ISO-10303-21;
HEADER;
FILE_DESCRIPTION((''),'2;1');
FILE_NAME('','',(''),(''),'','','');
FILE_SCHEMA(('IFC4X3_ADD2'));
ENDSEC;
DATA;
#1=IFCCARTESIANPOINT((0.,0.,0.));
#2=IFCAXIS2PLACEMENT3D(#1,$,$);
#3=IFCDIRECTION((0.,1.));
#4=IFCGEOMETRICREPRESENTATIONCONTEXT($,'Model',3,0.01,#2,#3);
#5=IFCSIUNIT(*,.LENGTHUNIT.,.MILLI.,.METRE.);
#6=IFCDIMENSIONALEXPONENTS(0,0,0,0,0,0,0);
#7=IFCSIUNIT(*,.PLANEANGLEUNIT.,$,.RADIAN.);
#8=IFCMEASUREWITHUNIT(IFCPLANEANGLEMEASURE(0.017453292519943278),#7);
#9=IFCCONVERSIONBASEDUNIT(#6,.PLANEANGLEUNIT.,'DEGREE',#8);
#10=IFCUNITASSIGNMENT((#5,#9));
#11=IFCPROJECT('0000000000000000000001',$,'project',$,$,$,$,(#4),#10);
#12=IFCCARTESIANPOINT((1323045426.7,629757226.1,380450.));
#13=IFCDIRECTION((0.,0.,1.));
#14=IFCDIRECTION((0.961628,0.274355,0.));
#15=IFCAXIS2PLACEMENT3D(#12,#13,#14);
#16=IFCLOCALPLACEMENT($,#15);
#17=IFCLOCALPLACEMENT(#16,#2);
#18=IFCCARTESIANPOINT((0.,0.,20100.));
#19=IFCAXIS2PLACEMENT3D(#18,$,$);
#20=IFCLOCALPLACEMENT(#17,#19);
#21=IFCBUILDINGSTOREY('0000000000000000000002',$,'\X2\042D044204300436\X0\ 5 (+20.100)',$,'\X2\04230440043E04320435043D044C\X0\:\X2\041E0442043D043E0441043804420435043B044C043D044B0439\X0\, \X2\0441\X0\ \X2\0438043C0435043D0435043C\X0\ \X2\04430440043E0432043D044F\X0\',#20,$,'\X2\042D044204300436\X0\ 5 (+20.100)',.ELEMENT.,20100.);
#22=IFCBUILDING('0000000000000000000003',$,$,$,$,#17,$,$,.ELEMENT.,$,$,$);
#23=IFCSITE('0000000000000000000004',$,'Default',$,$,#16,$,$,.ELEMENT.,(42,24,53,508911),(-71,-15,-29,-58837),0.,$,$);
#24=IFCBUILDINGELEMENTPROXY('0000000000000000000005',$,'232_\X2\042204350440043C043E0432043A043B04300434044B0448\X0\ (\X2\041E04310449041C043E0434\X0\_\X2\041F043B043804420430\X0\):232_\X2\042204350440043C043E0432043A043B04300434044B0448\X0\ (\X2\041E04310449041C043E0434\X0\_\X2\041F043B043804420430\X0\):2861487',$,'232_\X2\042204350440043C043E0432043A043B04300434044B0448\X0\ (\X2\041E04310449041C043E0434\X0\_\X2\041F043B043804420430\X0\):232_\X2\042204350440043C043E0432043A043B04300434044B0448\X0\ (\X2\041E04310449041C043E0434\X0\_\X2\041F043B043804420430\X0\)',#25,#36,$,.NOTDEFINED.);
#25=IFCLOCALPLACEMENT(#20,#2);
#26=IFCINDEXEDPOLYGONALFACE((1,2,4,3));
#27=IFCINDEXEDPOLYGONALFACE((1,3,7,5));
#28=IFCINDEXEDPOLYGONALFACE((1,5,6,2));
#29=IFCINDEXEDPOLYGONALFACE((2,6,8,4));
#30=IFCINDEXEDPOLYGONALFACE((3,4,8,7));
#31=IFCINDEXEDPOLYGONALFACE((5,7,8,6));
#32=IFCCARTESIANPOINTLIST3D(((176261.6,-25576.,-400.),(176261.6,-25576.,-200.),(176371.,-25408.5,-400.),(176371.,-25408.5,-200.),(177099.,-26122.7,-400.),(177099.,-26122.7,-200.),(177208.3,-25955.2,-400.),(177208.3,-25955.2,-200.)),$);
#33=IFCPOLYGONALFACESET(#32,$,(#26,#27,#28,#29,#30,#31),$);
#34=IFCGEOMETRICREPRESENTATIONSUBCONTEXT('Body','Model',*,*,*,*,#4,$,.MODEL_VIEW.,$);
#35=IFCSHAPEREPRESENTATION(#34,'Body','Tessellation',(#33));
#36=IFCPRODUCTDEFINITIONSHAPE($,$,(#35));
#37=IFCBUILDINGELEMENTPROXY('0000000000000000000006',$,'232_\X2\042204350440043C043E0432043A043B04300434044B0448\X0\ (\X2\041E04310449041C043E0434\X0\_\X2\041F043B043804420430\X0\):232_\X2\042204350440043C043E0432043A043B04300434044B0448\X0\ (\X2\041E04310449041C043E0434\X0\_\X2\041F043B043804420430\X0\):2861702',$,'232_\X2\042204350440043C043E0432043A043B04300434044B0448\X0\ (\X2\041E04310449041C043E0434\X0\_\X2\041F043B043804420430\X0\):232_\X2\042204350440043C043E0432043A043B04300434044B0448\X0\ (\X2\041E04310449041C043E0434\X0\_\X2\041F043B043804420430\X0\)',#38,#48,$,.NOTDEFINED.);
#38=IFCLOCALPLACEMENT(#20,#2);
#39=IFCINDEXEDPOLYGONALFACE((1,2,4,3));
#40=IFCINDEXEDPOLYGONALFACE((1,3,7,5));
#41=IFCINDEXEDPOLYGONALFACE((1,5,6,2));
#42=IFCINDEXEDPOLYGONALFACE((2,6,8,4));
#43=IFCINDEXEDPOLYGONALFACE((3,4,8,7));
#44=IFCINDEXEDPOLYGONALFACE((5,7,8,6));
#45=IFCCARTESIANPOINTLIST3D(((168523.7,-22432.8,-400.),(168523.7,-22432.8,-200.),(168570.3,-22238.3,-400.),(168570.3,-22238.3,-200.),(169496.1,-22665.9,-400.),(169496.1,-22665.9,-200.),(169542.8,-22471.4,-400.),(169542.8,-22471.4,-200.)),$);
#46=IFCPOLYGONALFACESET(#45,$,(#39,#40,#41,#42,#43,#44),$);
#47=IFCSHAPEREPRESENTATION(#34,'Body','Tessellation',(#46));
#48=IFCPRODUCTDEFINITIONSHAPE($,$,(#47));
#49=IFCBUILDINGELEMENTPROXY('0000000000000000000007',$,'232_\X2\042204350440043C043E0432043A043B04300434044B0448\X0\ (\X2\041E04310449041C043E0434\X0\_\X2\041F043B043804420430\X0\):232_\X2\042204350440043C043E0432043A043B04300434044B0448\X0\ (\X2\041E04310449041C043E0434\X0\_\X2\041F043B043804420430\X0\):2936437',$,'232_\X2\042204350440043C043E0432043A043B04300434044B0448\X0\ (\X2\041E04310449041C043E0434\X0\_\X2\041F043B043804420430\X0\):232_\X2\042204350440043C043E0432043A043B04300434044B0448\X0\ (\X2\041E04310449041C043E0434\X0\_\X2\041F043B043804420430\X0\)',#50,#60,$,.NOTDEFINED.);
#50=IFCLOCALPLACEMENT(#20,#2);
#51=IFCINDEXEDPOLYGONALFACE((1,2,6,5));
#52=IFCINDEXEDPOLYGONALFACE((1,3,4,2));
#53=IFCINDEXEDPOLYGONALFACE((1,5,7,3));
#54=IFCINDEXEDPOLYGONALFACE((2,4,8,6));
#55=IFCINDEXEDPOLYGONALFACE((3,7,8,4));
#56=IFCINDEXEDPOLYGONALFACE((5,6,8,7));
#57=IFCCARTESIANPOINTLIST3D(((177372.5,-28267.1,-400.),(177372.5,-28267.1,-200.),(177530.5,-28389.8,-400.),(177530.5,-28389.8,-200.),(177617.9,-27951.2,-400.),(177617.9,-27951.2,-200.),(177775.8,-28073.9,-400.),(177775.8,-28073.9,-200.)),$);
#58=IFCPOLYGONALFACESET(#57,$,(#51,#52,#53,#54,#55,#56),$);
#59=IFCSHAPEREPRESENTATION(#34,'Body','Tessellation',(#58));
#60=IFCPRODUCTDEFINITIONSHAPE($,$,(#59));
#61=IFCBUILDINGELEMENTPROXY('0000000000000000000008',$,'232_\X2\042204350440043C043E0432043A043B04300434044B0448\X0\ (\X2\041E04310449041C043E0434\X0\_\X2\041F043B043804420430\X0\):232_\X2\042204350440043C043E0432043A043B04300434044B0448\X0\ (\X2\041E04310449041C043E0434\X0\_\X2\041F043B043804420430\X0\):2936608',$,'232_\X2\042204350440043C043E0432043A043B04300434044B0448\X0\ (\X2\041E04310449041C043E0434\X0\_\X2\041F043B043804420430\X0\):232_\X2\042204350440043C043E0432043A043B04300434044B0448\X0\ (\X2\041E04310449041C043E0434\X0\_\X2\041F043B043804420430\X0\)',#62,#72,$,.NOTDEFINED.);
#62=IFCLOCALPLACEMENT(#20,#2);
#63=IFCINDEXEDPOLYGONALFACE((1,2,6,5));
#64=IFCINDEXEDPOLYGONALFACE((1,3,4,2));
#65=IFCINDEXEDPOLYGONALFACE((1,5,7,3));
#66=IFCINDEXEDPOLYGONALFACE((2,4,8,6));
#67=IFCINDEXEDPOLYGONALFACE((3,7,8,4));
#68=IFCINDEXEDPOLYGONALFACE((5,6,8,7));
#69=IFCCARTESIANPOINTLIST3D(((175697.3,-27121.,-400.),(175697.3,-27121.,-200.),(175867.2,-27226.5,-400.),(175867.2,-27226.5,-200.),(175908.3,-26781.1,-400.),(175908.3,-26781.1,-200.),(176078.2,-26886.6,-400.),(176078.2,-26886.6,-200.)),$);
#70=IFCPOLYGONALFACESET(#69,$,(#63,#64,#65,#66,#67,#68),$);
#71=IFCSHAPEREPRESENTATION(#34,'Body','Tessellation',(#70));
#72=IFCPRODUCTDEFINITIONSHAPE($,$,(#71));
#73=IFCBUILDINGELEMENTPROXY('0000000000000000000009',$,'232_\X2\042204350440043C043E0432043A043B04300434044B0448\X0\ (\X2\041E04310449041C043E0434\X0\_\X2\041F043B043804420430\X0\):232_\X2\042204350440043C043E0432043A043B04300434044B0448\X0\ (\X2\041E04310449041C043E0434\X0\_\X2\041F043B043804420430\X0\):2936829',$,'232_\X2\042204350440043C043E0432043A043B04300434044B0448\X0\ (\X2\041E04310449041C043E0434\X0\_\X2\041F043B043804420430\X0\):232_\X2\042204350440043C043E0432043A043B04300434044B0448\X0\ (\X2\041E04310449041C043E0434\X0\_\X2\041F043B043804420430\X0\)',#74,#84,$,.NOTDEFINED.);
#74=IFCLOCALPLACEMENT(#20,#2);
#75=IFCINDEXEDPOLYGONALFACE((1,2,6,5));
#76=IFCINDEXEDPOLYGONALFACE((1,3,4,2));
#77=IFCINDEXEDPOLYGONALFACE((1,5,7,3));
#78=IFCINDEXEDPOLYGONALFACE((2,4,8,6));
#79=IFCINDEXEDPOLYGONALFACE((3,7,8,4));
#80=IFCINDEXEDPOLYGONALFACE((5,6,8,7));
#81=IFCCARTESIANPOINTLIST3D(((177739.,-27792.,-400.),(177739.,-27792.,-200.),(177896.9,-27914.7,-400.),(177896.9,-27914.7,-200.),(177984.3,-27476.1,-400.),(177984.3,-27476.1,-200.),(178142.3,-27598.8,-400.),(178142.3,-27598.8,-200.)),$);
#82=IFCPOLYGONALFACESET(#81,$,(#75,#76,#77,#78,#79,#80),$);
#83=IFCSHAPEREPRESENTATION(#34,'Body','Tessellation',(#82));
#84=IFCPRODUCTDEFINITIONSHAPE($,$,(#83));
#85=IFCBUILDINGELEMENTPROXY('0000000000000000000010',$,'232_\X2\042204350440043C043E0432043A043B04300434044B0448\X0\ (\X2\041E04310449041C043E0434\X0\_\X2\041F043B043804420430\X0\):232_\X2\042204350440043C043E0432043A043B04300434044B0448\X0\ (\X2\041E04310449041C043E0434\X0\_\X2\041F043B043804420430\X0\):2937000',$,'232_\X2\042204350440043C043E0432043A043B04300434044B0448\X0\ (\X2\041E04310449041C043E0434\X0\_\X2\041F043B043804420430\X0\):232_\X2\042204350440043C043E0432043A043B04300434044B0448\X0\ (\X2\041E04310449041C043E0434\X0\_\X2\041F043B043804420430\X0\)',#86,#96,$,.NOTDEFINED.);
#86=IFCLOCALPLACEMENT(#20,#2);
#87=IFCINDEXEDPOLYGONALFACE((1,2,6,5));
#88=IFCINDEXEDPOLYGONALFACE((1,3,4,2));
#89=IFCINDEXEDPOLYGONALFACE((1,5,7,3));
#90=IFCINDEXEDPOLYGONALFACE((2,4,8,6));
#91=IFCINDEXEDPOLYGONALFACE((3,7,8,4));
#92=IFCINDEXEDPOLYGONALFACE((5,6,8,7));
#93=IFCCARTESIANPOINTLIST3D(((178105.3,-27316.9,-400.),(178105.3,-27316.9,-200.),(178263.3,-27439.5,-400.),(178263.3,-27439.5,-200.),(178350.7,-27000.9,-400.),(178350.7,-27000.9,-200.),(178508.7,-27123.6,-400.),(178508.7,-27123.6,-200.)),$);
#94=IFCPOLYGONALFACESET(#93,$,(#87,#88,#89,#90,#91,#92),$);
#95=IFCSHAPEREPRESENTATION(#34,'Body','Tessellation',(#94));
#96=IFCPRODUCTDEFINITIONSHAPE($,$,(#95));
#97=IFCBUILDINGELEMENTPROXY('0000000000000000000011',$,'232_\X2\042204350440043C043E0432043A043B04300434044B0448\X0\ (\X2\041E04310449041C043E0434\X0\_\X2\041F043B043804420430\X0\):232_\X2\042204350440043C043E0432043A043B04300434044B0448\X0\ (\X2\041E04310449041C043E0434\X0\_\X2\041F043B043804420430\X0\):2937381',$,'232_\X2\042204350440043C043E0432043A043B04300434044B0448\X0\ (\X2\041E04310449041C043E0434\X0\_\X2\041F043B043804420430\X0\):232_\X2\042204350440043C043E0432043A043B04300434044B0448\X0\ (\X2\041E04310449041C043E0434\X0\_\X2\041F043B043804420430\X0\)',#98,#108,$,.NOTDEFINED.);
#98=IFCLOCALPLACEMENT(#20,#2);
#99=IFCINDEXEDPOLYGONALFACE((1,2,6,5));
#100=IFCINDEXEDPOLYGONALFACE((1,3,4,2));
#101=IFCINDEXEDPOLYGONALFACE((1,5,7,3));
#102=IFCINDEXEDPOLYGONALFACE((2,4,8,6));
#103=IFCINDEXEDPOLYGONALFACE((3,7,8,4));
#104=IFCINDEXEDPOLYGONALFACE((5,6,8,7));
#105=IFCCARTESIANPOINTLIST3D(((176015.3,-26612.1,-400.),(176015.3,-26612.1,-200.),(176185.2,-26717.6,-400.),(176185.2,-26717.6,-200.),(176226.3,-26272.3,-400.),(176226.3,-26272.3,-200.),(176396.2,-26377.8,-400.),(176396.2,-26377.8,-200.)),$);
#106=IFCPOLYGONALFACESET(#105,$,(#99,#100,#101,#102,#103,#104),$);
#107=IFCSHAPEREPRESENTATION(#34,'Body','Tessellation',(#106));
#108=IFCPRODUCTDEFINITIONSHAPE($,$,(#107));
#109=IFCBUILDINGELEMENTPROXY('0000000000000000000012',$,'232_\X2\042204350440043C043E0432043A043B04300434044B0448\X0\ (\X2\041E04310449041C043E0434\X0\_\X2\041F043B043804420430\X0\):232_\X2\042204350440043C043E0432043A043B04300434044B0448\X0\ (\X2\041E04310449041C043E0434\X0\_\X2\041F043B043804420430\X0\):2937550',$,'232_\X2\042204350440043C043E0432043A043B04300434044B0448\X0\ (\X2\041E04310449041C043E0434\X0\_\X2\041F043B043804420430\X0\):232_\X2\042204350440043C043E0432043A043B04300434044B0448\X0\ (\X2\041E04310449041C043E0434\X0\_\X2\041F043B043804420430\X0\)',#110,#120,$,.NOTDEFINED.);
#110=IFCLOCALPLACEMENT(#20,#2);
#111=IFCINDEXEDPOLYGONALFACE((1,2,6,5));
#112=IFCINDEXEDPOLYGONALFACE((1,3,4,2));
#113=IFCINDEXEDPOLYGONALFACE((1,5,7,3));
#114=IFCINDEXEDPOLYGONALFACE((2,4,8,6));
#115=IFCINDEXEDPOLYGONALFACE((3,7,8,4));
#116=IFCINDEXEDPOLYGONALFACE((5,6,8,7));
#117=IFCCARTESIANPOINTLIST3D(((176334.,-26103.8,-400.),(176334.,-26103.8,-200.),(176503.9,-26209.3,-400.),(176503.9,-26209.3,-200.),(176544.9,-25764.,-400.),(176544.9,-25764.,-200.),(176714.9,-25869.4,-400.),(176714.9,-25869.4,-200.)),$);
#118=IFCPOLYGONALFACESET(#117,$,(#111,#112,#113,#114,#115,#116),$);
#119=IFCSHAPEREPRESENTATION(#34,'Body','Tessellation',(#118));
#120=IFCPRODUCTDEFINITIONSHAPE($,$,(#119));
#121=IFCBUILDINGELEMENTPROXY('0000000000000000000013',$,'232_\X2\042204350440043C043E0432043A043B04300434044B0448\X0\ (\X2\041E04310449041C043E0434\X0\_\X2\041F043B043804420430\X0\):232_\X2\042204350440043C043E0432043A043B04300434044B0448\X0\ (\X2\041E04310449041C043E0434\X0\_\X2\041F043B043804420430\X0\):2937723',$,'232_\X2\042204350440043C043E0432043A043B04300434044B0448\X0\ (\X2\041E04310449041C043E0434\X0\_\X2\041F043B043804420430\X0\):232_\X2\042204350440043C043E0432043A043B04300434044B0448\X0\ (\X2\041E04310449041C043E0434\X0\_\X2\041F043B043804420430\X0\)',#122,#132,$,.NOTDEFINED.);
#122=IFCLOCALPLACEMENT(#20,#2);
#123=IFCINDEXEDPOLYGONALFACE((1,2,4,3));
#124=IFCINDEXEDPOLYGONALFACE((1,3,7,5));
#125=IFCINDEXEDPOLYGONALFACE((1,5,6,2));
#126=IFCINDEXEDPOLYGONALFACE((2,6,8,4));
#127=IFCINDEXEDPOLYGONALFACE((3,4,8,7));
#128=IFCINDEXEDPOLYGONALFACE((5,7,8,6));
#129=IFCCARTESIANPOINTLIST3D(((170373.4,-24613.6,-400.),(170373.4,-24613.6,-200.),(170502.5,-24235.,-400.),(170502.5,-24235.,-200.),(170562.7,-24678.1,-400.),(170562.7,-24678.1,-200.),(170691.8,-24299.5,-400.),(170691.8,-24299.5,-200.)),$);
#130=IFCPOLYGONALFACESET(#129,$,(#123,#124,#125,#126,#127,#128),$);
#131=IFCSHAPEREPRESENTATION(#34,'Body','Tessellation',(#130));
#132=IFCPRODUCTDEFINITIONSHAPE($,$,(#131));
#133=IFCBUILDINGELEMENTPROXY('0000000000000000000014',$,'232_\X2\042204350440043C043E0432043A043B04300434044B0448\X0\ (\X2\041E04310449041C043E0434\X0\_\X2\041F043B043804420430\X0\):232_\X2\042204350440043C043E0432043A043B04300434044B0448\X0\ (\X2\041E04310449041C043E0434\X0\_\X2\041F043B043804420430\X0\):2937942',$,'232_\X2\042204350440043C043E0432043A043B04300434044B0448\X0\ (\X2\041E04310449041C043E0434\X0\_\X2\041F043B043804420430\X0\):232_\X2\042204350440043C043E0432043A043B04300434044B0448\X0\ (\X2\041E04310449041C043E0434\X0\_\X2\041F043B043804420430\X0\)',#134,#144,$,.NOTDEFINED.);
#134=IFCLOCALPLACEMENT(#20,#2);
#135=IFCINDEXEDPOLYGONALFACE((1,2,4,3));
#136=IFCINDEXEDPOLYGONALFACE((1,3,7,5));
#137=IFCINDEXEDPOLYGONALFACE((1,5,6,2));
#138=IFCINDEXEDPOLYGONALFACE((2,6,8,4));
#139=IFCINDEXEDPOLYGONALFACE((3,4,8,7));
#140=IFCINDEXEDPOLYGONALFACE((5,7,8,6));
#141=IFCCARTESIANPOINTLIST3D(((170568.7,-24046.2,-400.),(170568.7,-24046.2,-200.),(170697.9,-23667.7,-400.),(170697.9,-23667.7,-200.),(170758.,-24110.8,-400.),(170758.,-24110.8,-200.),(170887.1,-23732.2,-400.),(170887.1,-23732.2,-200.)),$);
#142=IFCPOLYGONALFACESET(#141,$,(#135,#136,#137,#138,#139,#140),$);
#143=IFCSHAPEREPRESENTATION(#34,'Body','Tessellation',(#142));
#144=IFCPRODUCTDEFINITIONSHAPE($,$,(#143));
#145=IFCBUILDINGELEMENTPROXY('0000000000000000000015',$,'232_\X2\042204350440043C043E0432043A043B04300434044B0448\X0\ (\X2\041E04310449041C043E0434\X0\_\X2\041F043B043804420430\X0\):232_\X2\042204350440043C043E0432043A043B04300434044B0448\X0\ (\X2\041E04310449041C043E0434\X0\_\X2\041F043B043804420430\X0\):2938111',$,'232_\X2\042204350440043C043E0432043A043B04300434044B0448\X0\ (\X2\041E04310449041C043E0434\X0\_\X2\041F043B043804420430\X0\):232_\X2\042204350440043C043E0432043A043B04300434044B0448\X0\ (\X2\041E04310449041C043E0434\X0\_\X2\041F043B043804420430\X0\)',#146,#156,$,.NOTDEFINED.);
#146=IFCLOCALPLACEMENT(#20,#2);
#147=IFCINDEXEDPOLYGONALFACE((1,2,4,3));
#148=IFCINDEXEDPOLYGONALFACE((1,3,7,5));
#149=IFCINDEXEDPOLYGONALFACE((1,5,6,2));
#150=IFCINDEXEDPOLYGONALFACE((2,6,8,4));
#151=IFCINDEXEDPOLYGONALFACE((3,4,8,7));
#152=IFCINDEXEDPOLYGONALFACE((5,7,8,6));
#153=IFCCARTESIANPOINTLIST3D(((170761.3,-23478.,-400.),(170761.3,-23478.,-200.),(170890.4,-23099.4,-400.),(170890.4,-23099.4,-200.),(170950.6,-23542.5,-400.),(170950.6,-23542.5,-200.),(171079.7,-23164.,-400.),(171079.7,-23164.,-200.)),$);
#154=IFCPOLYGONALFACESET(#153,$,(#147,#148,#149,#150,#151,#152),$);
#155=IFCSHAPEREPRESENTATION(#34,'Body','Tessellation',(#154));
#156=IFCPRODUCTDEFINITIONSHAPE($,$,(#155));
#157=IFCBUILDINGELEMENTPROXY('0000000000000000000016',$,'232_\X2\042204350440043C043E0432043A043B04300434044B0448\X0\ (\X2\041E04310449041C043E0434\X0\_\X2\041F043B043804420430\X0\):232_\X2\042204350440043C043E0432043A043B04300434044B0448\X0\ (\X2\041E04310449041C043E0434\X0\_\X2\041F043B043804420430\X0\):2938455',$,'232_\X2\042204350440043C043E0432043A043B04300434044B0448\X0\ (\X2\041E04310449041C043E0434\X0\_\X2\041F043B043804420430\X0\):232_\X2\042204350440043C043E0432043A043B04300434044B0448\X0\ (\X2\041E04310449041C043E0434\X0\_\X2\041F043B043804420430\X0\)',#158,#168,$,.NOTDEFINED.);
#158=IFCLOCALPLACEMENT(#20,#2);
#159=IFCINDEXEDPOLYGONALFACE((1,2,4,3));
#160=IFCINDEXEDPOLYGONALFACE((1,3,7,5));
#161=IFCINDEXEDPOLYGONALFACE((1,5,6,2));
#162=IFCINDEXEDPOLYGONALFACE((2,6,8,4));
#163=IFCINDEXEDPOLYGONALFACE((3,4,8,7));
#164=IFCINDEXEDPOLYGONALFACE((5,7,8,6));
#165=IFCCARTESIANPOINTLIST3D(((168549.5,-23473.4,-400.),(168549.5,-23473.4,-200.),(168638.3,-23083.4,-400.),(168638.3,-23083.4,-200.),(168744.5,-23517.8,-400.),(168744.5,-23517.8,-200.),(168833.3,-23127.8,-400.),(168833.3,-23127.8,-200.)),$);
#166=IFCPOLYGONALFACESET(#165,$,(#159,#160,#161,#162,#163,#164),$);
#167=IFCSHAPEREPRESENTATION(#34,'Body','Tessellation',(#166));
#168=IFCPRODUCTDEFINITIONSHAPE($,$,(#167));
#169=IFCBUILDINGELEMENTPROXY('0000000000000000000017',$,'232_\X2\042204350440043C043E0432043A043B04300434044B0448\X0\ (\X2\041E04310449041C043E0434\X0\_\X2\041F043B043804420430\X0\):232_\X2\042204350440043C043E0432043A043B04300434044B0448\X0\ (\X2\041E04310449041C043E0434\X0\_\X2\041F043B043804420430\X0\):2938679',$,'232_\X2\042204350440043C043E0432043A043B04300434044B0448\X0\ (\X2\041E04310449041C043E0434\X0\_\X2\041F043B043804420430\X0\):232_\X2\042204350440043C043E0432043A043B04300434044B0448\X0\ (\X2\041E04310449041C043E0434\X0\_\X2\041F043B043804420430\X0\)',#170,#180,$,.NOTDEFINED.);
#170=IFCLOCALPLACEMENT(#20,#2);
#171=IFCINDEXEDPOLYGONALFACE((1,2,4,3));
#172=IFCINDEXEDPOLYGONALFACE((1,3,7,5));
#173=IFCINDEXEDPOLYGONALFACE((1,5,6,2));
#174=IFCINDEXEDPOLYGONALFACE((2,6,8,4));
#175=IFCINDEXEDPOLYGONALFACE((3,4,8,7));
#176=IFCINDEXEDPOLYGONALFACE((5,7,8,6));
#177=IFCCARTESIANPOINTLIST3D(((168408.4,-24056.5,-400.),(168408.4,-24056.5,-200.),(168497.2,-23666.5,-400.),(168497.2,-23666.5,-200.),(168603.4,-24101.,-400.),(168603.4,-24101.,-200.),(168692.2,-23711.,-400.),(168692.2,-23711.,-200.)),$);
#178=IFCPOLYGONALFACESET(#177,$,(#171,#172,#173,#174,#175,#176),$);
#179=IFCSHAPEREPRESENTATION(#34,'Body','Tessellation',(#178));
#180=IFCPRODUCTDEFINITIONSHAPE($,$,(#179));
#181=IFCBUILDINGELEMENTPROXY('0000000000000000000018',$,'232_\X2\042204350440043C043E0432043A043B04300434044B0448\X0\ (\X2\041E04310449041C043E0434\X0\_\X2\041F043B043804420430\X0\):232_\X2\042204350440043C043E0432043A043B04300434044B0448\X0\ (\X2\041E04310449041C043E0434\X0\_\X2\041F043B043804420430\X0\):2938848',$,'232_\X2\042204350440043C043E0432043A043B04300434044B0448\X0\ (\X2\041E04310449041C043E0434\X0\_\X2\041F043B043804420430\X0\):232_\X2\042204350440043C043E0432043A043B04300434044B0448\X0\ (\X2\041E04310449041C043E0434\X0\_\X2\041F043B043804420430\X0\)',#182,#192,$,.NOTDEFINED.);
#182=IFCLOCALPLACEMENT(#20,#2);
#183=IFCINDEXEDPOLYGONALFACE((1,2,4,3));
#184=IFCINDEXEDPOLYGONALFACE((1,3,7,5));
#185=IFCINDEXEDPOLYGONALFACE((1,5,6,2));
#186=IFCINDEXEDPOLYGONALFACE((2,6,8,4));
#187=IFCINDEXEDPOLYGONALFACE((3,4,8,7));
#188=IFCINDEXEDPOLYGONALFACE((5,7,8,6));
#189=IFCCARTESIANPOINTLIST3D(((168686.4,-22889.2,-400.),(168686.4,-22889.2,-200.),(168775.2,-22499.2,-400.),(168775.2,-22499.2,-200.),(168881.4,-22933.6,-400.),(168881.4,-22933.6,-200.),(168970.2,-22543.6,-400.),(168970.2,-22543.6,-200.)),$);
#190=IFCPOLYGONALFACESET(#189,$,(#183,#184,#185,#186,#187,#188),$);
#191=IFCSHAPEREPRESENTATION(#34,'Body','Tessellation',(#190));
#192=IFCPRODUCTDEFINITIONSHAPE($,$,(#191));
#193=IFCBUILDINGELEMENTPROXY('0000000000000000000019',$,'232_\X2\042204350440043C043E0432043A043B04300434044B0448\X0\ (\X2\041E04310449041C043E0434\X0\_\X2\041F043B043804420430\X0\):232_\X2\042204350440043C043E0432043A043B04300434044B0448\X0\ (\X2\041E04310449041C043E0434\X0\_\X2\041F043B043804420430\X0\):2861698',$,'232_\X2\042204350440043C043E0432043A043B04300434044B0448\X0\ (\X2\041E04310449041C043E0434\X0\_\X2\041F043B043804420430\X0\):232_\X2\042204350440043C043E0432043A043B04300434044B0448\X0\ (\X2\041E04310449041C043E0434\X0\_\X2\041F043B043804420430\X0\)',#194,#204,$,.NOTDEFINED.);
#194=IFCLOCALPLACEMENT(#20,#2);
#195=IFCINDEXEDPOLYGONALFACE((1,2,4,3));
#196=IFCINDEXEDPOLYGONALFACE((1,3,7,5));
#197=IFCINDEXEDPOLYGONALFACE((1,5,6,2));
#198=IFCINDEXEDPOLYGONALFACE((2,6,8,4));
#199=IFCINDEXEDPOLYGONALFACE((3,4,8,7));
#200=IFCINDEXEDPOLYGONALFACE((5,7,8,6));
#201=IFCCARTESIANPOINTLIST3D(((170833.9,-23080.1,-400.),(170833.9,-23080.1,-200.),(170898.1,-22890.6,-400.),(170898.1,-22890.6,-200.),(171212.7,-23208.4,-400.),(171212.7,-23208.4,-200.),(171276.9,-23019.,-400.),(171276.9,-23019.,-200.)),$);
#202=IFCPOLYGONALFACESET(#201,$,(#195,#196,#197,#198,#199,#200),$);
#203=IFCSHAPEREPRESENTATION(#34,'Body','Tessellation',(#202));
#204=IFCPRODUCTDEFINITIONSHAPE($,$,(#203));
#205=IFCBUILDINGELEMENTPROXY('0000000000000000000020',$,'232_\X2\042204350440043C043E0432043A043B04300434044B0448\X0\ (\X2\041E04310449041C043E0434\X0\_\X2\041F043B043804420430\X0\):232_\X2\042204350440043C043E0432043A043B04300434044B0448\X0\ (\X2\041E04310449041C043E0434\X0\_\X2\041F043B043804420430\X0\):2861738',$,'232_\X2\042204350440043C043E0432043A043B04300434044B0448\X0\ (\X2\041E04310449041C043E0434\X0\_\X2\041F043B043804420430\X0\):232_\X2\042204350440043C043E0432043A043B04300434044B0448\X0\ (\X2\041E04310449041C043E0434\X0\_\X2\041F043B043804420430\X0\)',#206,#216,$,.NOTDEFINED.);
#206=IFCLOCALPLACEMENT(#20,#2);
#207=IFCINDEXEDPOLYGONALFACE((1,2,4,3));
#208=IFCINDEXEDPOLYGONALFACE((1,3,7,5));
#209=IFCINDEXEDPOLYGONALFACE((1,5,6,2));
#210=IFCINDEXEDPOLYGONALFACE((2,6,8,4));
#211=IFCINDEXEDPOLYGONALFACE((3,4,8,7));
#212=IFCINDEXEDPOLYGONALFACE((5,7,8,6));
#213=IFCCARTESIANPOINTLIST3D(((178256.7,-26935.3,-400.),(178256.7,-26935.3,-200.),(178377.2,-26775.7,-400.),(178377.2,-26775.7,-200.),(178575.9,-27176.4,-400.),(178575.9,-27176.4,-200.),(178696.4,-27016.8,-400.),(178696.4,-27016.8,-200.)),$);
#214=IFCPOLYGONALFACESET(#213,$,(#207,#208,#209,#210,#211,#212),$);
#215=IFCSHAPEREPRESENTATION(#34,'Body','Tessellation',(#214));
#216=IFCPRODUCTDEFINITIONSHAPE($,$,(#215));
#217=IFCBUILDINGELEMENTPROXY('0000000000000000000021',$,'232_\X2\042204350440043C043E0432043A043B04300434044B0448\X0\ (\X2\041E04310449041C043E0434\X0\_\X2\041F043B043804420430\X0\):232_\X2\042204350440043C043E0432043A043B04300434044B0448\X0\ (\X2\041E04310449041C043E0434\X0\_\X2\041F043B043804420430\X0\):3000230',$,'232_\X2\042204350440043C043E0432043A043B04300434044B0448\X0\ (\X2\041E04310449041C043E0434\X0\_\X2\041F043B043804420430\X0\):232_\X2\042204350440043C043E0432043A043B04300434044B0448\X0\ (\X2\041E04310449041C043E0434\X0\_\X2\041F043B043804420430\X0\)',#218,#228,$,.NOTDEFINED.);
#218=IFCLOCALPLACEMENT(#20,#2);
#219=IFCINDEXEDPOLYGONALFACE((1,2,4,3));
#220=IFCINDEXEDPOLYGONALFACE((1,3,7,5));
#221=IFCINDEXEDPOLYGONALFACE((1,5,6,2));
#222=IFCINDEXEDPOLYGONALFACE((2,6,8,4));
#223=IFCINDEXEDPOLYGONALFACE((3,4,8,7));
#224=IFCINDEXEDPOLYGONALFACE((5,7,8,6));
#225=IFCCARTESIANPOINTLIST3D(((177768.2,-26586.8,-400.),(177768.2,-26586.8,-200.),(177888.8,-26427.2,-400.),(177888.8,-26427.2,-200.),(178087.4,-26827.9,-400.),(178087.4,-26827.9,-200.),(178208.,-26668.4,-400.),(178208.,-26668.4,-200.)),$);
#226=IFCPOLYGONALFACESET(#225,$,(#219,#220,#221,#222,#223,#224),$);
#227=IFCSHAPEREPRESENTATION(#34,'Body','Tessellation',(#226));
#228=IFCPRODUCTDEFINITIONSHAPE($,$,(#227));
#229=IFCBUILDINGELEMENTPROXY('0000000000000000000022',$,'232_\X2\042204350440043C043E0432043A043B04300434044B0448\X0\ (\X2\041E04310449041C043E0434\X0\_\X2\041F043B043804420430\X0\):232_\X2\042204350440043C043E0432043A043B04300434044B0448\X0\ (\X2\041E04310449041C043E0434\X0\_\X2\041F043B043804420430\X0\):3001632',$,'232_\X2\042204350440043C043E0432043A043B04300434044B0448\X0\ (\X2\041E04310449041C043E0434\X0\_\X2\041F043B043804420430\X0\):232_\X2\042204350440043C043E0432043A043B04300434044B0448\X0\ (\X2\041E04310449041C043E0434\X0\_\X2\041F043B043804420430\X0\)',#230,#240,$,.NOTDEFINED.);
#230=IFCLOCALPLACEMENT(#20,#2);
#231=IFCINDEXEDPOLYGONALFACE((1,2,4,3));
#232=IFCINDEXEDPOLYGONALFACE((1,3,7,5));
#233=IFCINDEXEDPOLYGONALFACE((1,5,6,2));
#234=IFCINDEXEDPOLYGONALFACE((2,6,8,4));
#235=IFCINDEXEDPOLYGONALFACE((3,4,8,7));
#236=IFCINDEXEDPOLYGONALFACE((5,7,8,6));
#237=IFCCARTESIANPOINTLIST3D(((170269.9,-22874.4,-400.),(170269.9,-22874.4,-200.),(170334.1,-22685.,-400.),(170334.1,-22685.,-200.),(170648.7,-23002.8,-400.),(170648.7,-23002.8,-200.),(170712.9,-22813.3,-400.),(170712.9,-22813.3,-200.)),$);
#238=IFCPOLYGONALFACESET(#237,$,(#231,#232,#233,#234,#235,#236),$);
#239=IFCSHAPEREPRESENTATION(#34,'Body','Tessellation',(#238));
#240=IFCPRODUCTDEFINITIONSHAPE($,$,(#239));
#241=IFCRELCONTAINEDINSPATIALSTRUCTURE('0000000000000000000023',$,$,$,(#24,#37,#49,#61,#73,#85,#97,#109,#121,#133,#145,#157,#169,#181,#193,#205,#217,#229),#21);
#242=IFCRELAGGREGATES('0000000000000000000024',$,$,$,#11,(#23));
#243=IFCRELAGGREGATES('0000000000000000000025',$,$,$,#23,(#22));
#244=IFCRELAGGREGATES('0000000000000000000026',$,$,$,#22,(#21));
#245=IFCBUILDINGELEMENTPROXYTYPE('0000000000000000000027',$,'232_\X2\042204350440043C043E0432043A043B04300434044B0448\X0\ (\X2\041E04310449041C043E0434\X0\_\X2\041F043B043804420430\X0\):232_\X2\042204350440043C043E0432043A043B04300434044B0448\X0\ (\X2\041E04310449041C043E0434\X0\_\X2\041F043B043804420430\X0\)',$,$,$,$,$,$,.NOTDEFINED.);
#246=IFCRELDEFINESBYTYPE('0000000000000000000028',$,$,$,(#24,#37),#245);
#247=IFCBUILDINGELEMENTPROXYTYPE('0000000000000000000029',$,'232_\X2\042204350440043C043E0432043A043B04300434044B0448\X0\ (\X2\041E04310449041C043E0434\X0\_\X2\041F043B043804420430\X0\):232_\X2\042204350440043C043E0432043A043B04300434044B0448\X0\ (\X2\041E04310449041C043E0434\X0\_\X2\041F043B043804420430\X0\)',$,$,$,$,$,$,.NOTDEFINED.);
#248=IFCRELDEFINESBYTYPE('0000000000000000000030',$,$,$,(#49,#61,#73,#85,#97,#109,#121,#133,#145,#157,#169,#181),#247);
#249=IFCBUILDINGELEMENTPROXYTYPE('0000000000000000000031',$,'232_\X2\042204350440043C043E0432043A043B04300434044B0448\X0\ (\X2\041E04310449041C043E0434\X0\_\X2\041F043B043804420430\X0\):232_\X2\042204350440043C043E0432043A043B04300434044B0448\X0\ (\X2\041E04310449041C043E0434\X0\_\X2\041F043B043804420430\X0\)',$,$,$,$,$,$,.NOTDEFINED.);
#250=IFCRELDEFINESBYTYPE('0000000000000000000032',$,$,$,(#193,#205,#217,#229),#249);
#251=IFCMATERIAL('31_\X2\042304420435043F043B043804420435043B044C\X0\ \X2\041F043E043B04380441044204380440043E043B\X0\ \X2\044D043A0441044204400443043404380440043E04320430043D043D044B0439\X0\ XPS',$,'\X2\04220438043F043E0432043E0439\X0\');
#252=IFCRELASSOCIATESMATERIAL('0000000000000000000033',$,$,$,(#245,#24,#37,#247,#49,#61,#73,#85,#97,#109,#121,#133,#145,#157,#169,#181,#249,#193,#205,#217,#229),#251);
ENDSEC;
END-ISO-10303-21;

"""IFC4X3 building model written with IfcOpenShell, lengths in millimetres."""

from ifc_helpers import new_model, entity, si_unit, converted_unit, direction, frame, origin, origin_2d_with_axis, place, context, subcontext, project, spatial, rectangle, extrude, source, transform, mapped, material, type_object, type_shapes, element, save


model = new_model("IFC4X3")

# Units and contexts
model_context = context("Model", 3, precision=0.01, world=origin(), true_north=direction((0.0, 1.0)))
body_context = subcontext(model_context, "Body", "Model", "MODEL_VIEW")
ifc_project = project(units=[si_unit("LENGTHUNIT", "METRE", prefix="MILLI"), converted_unit("PLANEANGLEUNIT", "DEGREE", entity("IfcPlaneAngleMeasure", 0.017453292519943278), si_unit("PLANEANGLEUNIT", "RADIAN"), dimensions=[0, 0, 0, 0, 0, 0, 0])], contexts=[model_context])

# Site, building, storey
site_placement = place(None, frame((1323045426.7, 629757226.1, 380450.0), z_axis=(0.0, 0.0, 1.0), x_axis=(0.961628, 0.274355, 0.0)))
site = spatial("IfcSite", under=ifc_project, at=site_placement, Name="Default", CompositionType="ELEMENT", RefLatitude=(42, 24, 53, 508911), RefLongitude=(-71, -15, -29, -58837), RefElevation=0.0)
building_placement = place(site_placement, origin())
building = spatial("IfcBuilding", under=site, at=building_placement, CompositionType="ELEMENT")
storey_placement = place(building_placement, frame((0.0, 0.0, 20100.0)))
storey = spatial("IfcBuildingStorey", under=building, at=storey_placement, Name="Этаж 5 (+20.100)", ObjectType="Уровень:Относительный, с именем уровня", LongName="Этаж 5 (+20.100)", CompositionType="ELEMENT", Elevation=20100.0)

# Building element proxies
ifc_material = material(Name="31_Утеплитель Полистирол экструдированный XPS", Category="Типовой")
building_element_proxy_type_1 = type_object("IfcBuildingElementProxyType", Name="232_Термовкладыш (ОбщМод_Плита):232_Термовкладыш (ОбщМод_Плита)", PredefinedType="NOTDEFINED", material=ifc_material)
shared_shape_1 = source(origin(), body_context, "Body", "SweptSolid", [
    extrude(rectangle(XDim=1000.0, YDim=200.0, at=origin_2d_with_axis()), frame((500.0, 0.0, -200.0), z_axis=(0.0, 0.0, 1.0), x_axis=(-1.0, 0.0, 0.0)), (0.0, 0.0, 1.0), 200.0),
])
type_shapes(building_element_proxy_type_1, [shared_shape_1])
for number, where, z_axis, x_axis, name in (
    (1, (176316.3, -25492.3, -200.0), (0.0, 0.0, 1.0), (0.837365, -0.546644, 0.0), "232_Термовкладыш (ОбщМод_Плита):232_Термовкладыш (ОбщМод_Плита):2861487"),
    (2, (168547.0, -22335.6, -200.0), (0.0, 0.0, 1.0), (0.972461, -0.233066, 0.0), "232_Термовкладыш (ОбщМод_Плита):232_Термовкладыш (ОбщМод_Плита):2861702"),
):
    element("IfcBuildingElementProxy", number, at=place(storey_placement, frame(where, z_axis=z_axis, x_axis=x_axis)), inside=storey, type_object=building_element_proxy_type_1, material=ifc_material, Name=name, ObjectType="232_Термовкладыш (ОбщМод_Плита):232_Термовкладыш (ОбщМод_Плита)", PredefinedType="NOTDEFINED", context=body_context, shape_type="MappedRepresentation", body=[
        mapped(shared_shape_1, transform((0.0, 0.0, 0.0), scale=1.0)),
    ])
building_element_proxy_type_2 = type_object("IfcBuildingElementProxyType", Name="232_Термовкладыш (ОбщМод_Плита):232_Термовкладыш (ОбщМод_Плита)", PredefinedType="NOTDEFINED", material=ifc_material)
shared_shape_2 = source(origin(), body_context, "Body", "SweptSolid", [
    extrude(rectangle(XDim=200.0, YDim=400.0, at=origin_2d_with_axis()), frame((100.0, 0.0, -200.0), z_axis=(0.0, 0.0, 1.0), x_axis=(-1.0, 0.0, 0.0)), (0.0, 0.0, 1.0), 200.0),
])
type_shapes(building_element_proxy_type_2, [shared_shape_2])
for number, where, z_axis, x_axis, name in (
    (3, (177495.2, -28109.2, -200.0), (0.0, 0.0, 1.0), (0.789794, -0.613372, 0.0), "232_Термовкладыш (ОбщМод_Плита):232_Термовкладыш (ОбщМод_Плита):2936437"),
    (4, (175802.8, -26951.1, -200.0), (0.0, 0.0, 1.0), (0.849582, -0.527456, 0.0), "232_Термовкладыш (ОбщМод_Плита):232_Термовкладыш (ОбщМод_Плита):2936608"),
    (5, (177861.6, -27634.0, -200.0), (0.0, 0.0, 1.0), (0.789794, -0.613372, 0.0), "232_Термовкладыш (ОбщМод_Плита):232_Термовкладыш (ОбщМод_Плита):2936829"),
    (6, (178228.0, -27158.9, -200.0), (0.0, 0.0, 1.0), (0.789794, -0.613372, 0.0), "232_Термовкладыш (ОбщМод_Плита):232_Термовкладыш (ОбщМод_Плита):2937000"),
    (7, (176120.8, -26442.2, -200.0), (0.0, 0.0, 1.0), (0.849582, -0.527456, 0.0), "232_Термовкладыш (ОбщМод_Плита):232_Термовкладыш (ОбщМод_Плита):2937381"),
    (8, (176439.5, -25933.9, -200.0), (0.0, 0.0, 1.0), (0.849582, -0.527456, 0.0), "232_Термовкладыш (ОбщМод_Плита):232_Термовкладыш (ОбщМод_Плита):2937550"),
    (9, (170438.0, -24424.3, -200.0), (0.0, 0.0, 1.0), (0.946459, -0.322823, 0.0), "232_Термовкладыш (ОбщМод_Плита):232_Термовкладыш (ОбщМод_Плита):2937723"),
    (10, (170633.3, -23856.9, -200.0), (0.0, 0.0, 1.0), (0.946459, -0.322823, 0.0), "232_Термовкладыш (ОбщМод_Плита):232_Термовкладыш (ОбщМод_Плита):2937942"),
    (11, (170825.9, -23288.7, -200.0), (0.0, 0.0, 1.0), (0.946459, -0.322823, 0.0), "232_Термовкладыш (ОбщМод_Плита):232_Термовкладыш (ОбщМод_Плита):2938111"),
    (12, (168593.9, -23278.4, -200.0), (0.0, 0.0, 1.0), (0.975019, -0.222123, 0.0), "232_Термовкладыш (ОбщМод_Плита):232_Термовкладыш (ОбщМод_Плита):2938455"),
    (13, (168452.8, -23861.5, -200.0), (0.0, 0.0, 1.0), (0.975019, -0.222123, 0.0), "232_Термовкладыш (ОбщМод_Плита):232_Термовкладыш (ОбщМод_Плита):2938679"),
    (14, (168730.8, -22694.2, -200.0), (0.0, 0.0, 1.0), (0.975019, -0.222123, 0.0), "232_Термовкладыш (ОбщМод_Плита):232_Термовкладыш (ОбщМод_Плита):2938848"),
):
    element("IfcBuildingElementProxy", number, at=place(storey_placement, frame(where, z_axis=z_axis, x_axis=x_axis)), inside=storey, type_object=building_element_proxy_type_2, material=ifc_material, Name=name, ObjectType="232_Термовкладыш (ОбщМод_Плита):232_Термовкладыш (ОбщМод_Плита)", PredefinedType="NOTDEFINED", context=body_context, shape_type="MappedRepresentation", body=[
        mapped(shared_shape_2, transform((0.0, 0.0, 0.0), scale=1.0)),
    ])
building_element_proxy_type_3 = type_object("IfcBuildingElementProxyType", Name="232_Термовкладыш (ОбщМод_Плита):232_Термовкладыш (ОбщМод_Плита)", PredefinedType="NOTDEFINED", material=ifc_material)
shared_shape_3 = source(origin(), body_context, "Body", "SweptSolid", [
    extrude(rectangle(XDim=400.0, YDim=200.0, at=origin_2d_with_axis()), frame((200.0, 0.0, -200.0), z_axis=(0.0, 0.0, 1.0), x_axis=(-1.0, 0.0, 0.0)), (0.0, 0.0, 1.0), 200.0),
])
type_shapes(building_element_proxy_type_3, [shared_shape_3])
for number, where, z_axis, x_axis, name in (
    (15, (170866.0, -22985.4, -200.0), (0.0, 0.0, 1.0), (0.947097, -0.320946, 0.0), "232_Термовкладыш (ОбщМод_Плита):232_Термовкладыш (ОбщМод_Плита):2861698"),
    (16, (178317.0, -26855.5, -200.0), (0.0, 0.0, 1.0), (0.797911, -0.602776, 0.0), "232_Термовкладыш (ОбщМод_Плита):232_Термовкладыш (ОбщМод_Плита):2861738"),
    (17, (177828.5, -26507.0, -200.0), (0.0, 0.0, 1.0), (0.797911, -0.602776, 0.0), "232_Термовкладыш (ОбщМод_Плита):232_Термовкладыш (ОбщМод_Плита):3000230"),
    (18, (170302.0, -22779.7, -200.0), (0.0, 0.0, 1.0), (0.947097, -0.320946, 0.0), "232_Термовкладыш (ОбщМод_Плита):232_Термовкладыш (ОбщМод_Плита):3001632"),
):
    element("IfcBuildingElementProxy", number, at=place(storey_placement, frame(where, z_axis=z_axis, x_axis=x_axis)), inside=storey, type_object=building_element_proxy_type_3, material=ifc_material, Name=name, ObjectType="232_Термовкладыш (ОбщМод_Плита):232_Термовкладыш (ОбщМод_Плита)", PredefinedType="NOTDEFINED", context=body_context, shape_type="MappedRepresentation", body=[
        mapped(shared_shape_3, transform((0.0, 0.0, 0.0), scale=1.0)),
    ])

save(model, "model.ifc")
